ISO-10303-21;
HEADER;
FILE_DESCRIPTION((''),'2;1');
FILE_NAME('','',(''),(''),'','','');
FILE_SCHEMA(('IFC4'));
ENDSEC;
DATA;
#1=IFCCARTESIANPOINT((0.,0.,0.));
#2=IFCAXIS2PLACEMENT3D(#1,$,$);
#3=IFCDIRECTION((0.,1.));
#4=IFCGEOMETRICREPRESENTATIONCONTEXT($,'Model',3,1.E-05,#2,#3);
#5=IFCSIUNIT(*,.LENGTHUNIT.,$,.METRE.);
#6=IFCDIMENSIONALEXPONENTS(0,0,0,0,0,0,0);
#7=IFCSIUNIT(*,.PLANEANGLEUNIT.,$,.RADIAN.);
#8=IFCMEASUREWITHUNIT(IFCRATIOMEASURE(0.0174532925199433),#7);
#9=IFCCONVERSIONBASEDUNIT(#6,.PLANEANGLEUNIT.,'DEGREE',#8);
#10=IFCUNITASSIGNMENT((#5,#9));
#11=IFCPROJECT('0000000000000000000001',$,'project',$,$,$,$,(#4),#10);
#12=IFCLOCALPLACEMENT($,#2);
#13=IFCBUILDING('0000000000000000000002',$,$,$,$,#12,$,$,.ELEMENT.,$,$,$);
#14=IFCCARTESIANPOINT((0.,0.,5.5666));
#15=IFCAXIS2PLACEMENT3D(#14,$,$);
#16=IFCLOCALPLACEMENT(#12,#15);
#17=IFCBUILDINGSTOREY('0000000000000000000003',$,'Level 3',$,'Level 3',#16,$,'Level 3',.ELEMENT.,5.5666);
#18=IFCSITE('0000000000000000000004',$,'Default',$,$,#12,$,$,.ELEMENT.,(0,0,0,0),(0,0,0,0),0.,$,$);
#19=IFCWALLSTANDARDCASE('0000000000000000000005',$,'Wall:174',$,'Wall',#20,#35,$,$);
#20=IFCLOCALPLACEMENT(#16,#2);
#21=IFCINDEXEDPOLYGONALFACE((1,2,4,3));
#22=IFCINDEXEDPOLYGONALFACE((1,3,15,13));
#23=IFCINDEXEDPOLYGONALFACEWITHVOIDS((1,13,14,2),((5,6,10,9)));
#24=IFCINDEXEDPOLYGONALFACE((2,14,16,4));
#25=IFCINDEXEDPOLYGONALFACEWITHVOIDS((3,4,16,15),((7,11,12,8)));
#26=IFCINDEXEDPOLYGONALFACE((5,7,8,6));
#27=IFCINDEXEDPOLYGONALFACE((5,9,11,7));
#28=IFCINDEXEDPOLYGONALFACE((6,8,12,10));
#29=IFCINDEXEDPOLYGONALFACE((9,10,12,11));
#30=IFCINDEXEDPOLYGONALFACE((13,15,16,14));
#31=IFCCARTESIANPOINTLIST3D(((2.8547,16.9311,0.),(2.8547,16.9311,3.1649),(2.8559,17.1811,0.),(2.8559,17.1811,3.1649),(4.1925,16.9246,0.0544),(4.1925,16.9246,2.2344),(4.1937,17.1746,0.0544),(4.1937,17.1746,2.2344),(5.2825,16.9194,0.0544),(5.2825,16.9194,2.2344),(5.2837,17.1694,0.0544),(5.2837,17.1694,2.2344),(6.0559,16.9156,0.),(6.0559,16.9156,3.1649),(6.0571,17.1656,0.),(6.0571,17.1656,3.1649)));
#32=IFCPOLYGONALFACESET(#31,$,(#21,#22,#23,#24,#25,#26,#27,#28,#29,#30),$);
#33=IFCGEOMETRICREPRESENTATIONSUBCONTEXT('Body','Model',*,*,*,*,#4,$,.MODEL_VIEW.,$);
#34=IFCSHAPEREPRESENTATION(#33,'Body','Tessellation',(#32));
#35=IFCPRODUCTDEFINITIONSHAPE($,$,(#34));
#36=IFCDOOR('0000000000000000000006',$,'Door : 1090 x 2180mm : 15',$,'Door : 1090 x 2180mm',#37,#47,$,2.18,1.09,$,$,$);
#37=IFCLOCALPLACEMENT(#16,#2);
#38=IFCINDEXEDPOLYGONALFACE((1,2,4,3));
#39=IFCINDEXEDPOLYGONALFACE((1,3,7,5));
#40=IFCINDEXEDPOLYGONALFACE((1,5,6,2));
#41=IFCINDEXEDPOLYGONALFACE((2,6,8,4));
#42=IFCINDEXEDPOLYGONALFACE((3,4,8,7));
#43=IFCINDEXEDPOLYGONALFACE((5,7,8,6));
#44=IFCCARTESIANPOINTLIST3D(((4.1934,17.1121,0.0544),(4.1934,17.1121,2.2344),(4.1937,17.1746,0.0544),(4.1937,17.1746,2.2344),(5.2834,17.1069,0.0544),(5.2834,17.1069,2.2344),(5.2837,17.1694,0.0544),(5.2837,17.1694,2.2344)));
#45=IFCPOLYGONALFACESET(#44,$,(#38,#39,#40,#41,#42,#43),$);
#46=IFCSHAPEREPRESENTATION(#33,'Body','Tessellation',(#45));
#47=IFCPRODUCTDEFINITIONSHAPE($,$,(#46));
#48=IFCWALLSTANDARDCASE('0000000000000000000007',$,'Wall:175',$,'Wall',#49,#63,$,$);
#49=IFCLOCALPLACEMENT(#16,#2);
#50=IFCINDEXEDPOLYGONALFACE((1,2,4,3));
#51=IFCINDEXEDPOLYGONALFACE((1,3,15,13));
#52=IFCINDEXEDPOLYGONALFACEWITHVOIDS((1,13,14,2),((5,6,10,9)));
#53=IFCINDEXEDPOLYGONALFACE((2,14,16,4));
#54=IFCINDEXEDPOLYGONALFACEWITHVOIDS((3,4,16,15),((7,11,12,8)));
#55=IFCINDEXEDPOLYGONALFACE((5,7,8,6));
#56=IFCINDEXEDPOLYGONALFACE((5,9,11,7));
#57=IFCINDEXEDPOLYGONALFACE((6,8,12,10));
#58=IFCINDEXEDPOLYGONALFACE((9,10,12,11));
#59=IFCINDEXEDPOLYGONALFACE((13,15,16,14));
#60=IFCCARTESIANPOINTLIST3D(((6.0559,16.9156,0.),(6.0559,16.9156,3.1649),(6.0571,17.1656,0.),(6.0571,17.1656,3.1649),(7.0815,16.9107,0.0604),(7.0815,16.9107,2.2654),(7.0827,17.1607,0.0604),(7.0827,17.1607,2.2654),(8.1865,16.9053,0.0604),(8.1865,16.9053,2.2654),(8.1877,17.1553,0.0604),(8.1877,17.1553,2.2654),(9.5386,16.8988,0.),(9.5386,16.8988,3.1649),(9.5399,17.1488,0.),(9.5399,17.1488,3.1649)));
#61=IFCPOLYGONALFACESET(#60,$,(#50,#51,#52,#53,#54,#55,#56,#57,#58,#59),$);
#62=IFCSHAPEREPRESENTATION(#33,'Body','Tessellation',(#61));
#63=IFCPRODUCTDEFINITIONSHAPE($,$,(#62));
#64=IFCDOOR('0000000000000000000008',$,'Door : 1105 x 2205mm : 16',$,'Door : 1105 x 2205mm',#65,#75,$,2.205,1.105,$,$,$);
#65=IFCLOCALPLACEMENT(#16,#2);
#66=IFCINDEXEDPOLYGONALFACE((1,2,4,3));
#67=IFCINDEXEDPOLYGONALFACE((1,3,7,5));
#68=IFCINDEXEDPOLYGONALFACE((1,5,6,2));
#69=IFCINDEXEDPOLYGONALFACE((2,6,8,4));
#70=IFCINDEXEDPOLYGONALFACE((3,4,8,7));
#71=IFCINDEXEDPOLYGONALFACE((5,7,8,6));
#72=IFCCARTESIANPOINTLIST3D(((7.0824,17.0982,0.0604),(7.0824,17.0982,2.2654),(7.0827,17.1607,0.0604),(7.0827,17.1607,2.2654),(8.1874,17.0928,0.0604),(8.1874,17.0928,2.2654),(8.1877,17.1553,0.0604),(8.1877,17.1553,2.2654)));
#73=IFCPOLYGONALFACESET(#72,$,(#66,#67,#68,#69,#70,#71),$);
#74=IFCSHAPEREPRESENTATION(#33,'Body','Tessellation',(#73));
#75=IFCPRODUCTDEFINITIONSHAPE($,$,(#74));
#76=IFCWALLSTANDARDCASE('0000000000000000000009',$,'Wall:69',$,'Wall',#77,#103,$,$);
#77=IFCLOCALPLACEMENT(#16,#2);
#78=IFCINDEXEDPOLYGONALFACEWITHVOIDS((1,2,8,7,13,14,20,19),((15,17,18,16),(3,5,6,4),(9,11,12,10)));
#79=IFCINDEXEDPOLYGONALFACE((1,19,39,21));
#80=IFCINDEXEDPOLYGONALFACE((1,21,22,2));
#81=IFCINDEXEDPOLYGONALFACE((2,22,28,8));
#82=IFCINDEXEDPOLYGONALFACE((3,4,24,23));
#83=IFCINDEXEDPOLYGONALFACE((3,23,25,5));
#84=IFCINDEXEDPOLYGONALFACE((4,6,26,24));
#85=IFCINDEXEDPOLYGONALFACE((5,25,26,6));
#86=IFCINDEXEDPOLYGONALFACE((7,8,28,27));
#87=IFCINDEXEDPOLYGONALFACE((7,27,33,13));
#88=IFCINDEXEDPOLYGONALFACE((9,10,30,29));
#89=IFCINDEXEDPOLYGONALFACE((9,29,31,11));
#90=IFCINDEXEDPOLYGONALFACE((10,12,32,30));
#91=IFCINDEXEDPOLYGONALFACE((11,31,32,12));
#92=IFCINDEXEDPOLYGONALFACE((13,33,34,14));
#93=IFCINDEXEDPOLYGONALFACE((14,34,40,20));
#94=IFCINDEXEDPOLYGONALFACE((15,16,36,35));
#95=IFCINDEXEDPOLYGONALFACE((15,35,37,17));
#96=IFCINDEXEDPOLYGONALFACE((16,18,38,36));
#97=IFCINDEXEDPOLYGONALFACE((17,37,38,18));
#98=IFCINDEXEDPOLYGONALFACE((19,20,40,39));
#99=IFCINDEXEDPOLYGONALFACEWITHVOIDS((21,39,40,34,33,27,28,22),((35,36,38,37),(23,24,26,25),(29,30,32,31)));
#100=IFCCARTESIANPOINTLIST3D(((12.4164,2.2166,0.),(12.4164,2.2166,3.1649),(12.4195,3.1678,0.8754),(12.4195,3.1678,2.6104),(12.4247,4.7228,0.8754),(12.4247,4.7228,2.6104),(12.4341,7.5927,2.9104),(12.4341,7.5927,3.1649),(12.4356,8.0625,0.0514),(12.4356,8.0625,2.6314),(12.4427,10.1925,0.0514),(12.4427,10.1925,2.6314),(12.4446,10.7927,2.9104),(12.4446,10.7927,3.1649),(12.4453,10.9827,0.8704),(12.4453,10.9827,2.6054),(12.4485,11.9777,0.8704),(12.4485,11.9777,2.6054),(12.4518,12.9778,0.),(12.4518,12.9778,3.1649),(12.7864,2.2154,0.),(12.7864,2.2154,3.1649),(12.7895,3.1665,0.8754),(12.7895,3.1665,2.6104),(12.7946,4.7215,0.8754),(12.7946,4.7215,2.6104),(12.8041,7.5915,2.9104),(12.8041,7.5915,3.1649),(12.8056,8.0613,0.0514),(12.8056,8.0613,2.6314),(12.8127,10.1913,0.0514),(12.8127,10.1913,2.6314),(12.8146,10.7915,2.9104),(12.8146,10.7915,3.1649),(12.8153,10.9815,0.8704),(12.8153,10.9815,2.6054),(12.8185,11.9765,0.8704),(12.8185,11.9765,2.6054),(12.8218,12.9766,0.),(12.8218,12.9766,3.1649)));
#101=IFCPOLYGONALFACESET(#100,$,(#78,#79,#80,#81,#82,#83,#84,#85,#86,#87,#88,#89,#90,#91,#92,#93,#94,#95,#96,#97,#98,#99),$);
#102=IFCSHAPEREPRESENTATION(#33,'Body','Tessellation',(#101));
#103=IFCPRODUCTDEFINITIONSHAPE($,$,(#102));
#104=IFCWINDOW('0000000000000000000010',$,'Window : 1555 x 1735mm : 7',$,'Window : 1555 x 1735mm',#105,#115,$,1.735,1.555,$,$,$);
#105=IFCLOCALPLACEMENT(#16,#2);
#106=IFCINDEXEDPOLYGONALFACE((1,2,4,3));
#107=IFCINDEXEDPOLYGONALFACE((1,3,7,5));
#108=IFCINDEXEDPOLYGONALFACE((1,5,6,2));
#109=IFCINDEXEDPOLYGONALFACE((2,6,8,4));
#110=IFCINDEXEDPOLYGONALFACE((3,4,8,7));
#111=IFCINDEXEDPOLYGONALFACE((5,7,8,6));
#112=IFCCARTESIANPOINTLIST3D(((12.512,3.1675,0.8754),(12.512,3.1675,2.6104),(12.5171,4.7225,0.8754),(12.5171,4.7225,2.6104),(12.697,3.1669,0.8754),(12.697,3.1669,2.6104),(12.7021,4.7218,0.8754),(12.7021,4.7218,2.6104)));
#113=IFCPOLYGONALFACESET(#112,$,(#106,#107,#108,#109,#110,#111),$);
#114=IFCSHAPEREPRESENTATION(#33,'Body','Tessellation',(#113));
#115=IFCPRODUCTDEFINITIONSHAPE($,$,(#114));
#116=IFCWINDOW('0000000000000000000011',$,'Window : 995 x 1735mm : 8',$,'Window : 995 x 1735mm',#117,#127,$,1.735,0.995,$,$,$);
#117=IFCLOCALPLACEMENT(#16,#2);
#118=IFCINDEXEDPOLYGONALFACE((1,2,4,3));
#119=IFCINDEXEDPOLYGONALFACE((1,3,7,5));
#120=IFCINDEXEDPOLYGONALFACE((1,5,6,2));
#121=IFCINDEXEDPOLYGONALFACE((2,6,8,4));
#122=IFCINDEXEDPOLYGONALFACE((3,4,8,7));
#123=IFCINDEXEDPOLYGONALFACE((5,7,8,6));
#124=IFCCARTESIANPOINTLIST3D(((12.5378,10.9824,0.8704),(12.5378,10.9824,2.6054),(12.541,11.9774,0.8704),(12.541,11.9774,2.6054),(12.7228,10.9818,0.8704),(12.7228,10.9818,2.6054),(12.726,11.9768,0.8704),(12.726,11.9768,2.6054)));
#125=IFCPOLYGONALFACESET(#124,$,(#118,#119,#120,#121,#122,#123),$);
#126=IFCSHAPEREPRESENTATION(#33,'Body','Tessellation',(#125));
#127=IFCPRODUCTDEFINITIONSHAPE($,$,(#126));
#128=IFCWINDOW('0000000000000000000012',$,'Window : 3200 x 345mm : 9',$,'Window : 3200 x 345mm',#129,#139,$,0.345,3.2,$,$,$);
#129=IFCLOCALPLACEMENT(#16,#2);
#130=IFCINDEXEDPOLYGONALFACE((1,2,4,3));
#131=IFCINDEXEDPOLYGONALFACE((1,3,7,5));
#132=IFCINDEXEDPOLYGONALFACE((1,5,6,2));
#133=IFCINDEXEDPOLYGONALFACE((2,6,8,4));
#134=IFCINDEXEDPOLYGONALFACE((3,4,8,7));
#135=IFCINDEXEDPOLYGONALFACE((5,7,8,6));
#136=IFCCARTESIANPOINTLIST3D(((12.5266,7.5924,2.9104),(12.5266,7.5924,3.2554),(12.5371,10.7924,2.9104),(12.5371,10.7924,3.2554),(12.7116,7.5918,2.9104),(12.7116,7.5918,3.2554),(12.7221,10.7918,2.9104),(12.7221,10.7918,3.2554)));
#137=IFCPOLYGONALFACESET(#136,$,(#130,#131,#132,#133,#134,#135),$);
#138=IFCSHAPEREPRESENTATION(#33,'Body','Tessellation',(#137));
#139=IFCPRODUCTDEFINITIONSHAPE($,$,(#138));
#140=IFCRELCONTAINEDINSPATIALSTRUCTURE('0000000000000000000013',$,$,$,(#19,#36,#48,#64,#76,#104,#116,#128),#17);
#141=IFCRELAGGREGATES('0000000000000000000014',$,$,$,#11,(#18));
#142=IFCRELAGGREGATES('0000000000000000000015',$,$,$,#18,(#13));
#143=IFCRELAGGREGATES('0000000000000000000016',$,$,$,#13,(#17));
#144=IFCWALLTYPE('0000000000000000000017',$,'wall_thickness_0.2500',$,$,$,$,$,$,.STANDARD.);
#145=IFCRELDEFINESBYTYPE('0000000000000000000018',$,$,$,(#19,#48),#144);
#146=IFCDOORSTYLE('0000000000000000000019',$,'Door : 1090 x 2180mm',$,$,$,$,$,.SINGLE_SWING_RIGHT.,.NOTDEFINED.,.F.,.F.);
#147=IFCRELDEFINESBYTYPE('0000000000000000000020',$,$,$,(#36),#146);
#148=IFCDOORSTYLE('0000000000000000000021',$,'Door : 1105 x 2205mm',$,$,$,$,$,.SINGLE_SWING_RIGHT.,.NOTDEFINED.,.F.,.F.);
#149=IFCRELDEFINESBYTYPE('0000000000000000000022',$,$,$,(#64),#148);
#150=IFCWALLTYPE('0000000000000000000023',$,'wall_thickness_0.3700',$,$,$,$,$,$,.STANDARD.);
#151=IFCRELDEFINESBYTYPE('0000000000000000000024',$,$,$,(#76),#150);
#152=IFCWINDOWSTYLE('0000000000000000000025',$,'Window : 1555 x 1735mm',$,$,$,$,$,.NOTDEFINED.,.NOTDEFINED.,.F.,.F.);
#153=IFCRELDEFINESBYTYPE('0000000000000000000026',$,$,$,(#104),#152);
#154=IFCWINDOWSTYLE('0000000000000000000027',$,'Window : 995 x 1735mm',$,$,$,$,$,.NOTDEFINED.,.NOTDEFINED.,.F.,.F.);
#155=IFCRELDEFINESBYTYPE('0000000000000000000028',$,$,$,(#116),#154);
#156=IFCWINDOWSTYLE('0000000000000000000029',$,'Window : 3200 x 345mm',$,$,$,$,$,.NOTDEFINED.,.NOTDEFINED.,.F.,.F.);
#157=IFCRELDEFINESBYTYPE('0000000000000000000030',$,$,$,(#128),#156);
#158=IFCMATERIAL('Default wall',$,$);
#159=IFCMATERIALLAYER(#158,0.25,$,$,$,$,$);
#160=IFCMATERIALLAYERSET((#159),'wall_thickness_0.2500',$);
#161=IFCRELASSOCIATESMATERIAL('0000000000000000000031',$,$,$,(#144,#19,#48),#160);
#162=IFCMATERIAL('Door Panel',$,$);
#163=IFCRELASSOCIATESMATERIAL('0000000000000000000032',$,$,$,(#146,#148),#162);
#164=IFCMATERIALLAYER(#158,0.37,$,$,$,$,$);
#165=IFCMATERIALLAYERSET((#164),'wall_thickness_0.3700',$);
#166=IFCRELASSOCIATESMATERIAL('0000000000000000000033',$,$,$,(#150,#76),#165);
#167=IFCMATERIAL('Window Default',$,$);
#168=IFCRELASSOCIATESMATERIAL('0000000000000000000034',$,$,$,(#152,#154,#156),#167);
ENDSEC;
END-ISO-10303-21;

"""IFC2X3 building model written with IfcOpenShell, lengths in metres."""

from ifc_helpers import new_model, entity, si_unit, converted_unit, direction, frame, frame_2d, origin, origin_2d_with_axis, place, context, subcontext, project, spatial, polyline, rectangle, outline, extrude, source, transform, mapped, material, layer, layer_set, layer_usage, type_object, type_shapes, element, fill, save


model = new_model("IFC2X3")

# Units and contexts
model_context = context("Model", 3, precision=1e-05, world=origin(), true_north=direction((0.0, 1.0)))
body_context = subcontext(model_context, "Body", "Model", "MODEL_VIEW")
ifc_project = project(units=[si_unit("LENGTHUNIT", "METRE"), converted_unit("PLANEANGLEUNIT", "DEGREE", entity("IfcRatioMeasure", 0.0174532925199433), si_unit("PLANEANGLEUNIT", "RADIAN"), dimensions=[0, 0, 0, 0, 0, 0, 0])], contexts=[model_context])

# Site, building, storey
placement_1 = place(None, origin())
site = spatial("IfcSite", under=ifc_project, at=placement_1, Name="Default", CompositionType="ELEMENT", RefLatitude=(0, 0, 0, 0), RefLongitude=(0, 0, 0, 0), RefElevation=0.0)
building = spatial("IfcBuilding", under=site, at=placement_1, CompositionType="ELEMENT")
storey_placement = place(placement_1, frame((0.0, 0.0, 5.5666)))
storey = spatial("IfcBuildingStorey", under=building, at=storey_placement, Name="Level 3", ObjectType="Level 3", LongName="Level 3", CompositionType="ELEMENT", Elevation=5.5666)

# Shared definitions
ifc_material_1 = material(Name="Default wall")

# Shared definitions
ifc_material_2 = material(Name="Window Default")

# Shared definitions
ifc_layer_1 = layer(ifc_material_1, 0.25)
ifc_layer_set_1 = layer_set([ifc_layer_1], Name="wall_thickness_0.2500")
ifc_layer_usage_1 = layer_usage(ifc_layer_set_1, "AXIS2", "POSITIVE", -0.125)
wall_type_1 = type_object("IfcWallType", Name="wall_thickness_0.2500", PredefinedType="STANDARD", material=ifc_layer_set_1)

# Walls, openings, doors
wall_1_placement = place(storey_placement, frame((2.8553, 17.0561, 0.0), z_axis=(0.0, 0.0, 1.0), x_axis=(0.999988, -0.004836, 0.0)))
wall_1 = element("IfcWallStandardCase", 1, at=wall_1_placement, inside=storey, type_object=wall_type_1, material=ifc_layer_usage_1, Name="Wall:174", ObjectType="Wall", context=body_context, shape_type="SweptSolid", body=[
    extrude(outline(polyline([(3.2013, -0.125), (3.2013, 0.125), (0.0, 0.125), (0.0, -0.125), (3.2013, -0.125)])), origin(), (0.0, 0.0, 1.0), 3.1649),
])
opening_1_placement = place(wall_1_placement, frame((1.3378, -0.125, 0.0544)))
opening_1 = element("IfcOpeningElement", 2, at=opening_1_placement, cuts=wall_1, ObjectType="Opening", context=body_context, shape_type="SweptSolid", body=[
    extrude(rectangle(XDim=1.09, YDim=2.18, at=frame_2d((1.09, 0.545), x_axis=(0.0, 1.0))), frame((0.0, 0.0, 0.0), z_axis=(0.0, 1.0, 0.0), x_axis=(0.0, 0.0, 1.0)), (0.0, 0.0, 1.0), 0.25),
])
ifc_material_3 = material(Name="Door Panel")
door_style_1 = type_object("IfcDoorStyle", Name="Door : 1090 x 2180mm", ConstructionType="NOTDEFINED", OperationType="SINGLE_SWING_RIGHT", ParameterTakesPrecedence=False, Sizeable=False, material=ifc_material_3)
shared_shape_1 = source(origin(), body_context, "Body", "SweptSolid", [
    extrude(rectangle(XDim=0.0625, YDim=1.09, at=origin_2d_with_axis()), frame((0.545, 0.2188, 0.0), z_axis=(0.0, 0.0, 1.0), x_axis=(0.0, 1.0, 0.0)), (0.0, 0.0, 1.0), 2.18),
])
type_shapes(door_style_1, [shared_shape_1])
door_1_placement = place(opening_1_placement, origin())
door_1 = element("IfcDoor", 3, at=door_1_placement, inside=storey, type_object=door_style_1, Name="Door : 1090 x 2180mm : 15", ObjectType="Door : 1090 x 2180mm", OverallHeight=2.18, OverallWidth=1.09, context=body_context, shape_type="MappedRepresentation", body=[
    mapped(shared_shape_1, transform((0.0, 0.0, 0.0), scale=1.0)),
])
fill(opening_1, door_1)
wall_2_placement = place(storey_placement, frame((6.0565, 17.0406, 0.0), z_axis=(0.0, 0.0, 1.0), x_axis=(0.999988, -0.004836, 0.0)))
wall_2 = element("IfcWallStandardCase", 4, at=wall_2_placement, inside=storey, type_object=wall_type_1, material=ifc_layer_usage_1, Name="Wall:175", ObjectType="Wall", context=body_context, shape_type="SweptSolid", body=[
    extrude(outline(polyline([(3.4828, -0.125), (3.4828, 0.125), (0.0, 0.125), (0.0, -0.125), (3.4828, -0.125)])), origin(), (0.0, 0.0, 1.0), 3.1649),
])
opening_2_placement = place(wall_2_placement, frame((1.0256, -0.125, 0.0604)))
opening_2 = element("IfcOpeningElement", 5, at=opening_2_placement, cuts=wall_2, ObjectType="Opening", context=body_context, shape_type="SweptSolid", body=[
    extrude(rectangle(XDim=1.105, YDim=2.205, at=frame_2d((1.1025, 0.5525), x_axis=(0.0, 1.0))), frame((0.0, 0.0, 0.0), z_axis=(0.0, 1.0, 0.0), x_axis=(0.0, 0.0, 1.0)), (0.0, 0.0, 1.0), 0.25),
])
door_style_2 = type_object("IfcDoorStyle", Name="Door : 1105 x 2205mm", ConstructionType="NOTDEFINED", OperationType="SINGLE_SWING_RIGHT", ParameterTakesPrecedence=False, Sizeable=False, material=ifc_material_3)
shared_shape_2 = source(origin(), body_context, "Body", "SweptSolid", [
    extrude(rectangle(XDim=0.0625, YDim=1.105, at=origin_2d_with_axis()), frame((0.5525, 0.2188, 0.0), z_axis=(0.0, 0.0, 1.0), x_axis=(0.0, 1.0, 0.0)), (0.0, 0.0, 1.0), 2.205),
])
type_shapes(door_style_2, [shared_shape_2])
door_2_placement = place(opening_2_placement, origin())
door_2 = element("IfcDoor", 6, at=door_2_placement, inside=storey, type_object=door_style_2, Name="Door : 1105 x 2205mm : 16", ObjectType="Door : 1105 x 2205mm", OverallHeight=2.205, OverallWidth=1.105, context=body_context, shape_type="MappedRepresentation", body=[
    mapped(shared_shape_2, transform((0.0, 0.0, 0.0), scale=1.0)),
])
fill(opening_2, door_2)

# Wall, openings, windows
ifc_layer_2 = layer(ifc_material_1, 0.37)
ifc_layer_set_2 = layer_set([ifc_layer_2], Name="wall_thickness_0.3700")
ifc_layer_usage_2 = layer_usage(ifc_layer_set_2, "AXIS2", "POSITIVE", -0.185)
wall_type_2 = type_object("IfcWallType", Name="wall_thickness_0.3700", PredefinedType="STANDARD", material=ifc_layer_set_2)
wall_3_placement = place(storey_placement, frame((12.6368, 12.9772, 0.0), z_axis=(0.0, 0.0, 1.0), x_axis=(-0.003292, -0.999995, 0.0)))
wall_3 = element("IfcWallStandardCase", 7, at=wall_3_placement, inside=storey, type_object=wall_type_2, material=ifc_layer_usage_2, Name="Wall:69", ObjectType="Wall", context=body_context, shape_type="SweptSolid", body=[
    extrude(outline(polyline([(10.7612, -0.185), (10.7612, 0.185), (0.0, 0.185), (0.0, -0.185), (10.7612, -0.185)])), origin(), (0.0, 0.0, 1.0), 3.1649),
])
opening_3_placement = place(wall_3_placement, frame((2.7853, -0.185, 0.0514)))
element("IfcOpeningElement", 8, at=opening_3_placement, cuts=wall_3, ObjectType="Opening", context=body_context, shape_type="SweptSolid", body=[
    extrude(rectangle(XDim=2.13, YDim=2.58, at=frame_2d((1.29, 1.065), x_axis=(0.0, 1.0))), frame((0.0, 0.0, 0.0), z_axis=(0.0, 1.0, 0.0), x_axis=(0.0, 0.0, 1.0)), (0.0, 0.0, 1.0), 0.37),
])
opening_4_placement = place(wall_3_placement, frame((8.2551, -0.185, 0.8754)))
opening_4 = element("IfcOpeningElement", 9, at=opening_4_placement, cuts=wall_3, ObjectType="Opening", context=body_context, shape_type="SweptSolid", body=[
    extrude(rectangle(XDim=1.555, YDim=1.735, at=frame_2d((0.8675, 0.7775), x_axis=(0.0, 1.0))), frame((0.0, 0.0, 0.0), z_axis=(0.0, 1.0, 0.0), x_axis=(0.0, 0.0, 1.0)), (0.0, 0.0, 1.0), 0.37),
])
opening_5_placement = place(wall_3_placement, frame((1.0001, -0.185, 0.8704)))
opening_5 = element("IfcOpeningElement", 10, at=opening_5_placement, cuts=wall_3, ObjectType="Opening", context=body_context, shape_type="SweptSolid", body=[
    extrude(rectangle(XDim=0.995, YDim=1.735, at=frame_2d((0.8675, 0.4975), x_axis=(0.0, 1.0))), frame((0.0, 0.0, 0.0), z_axis=(0.0, 1.0, 0.0), x_axis=(0.0, 0.0, 1.0)), (0.0, 0.0, 1.0), 0.37),
])
opening_6_placement = place(wall_3_placement, frame((2.1851, -0.185, 2.9104)))
opening_6 = element("IfcOpeningElement", 11, at=opening_6_placement, cuts=wall_3, ObjectType="Opening", context=body_context, shape_type="SweptSolid", body=[
    extrude(rectangle(XDim=3.2, YDim=0.345, at=frame_2d((0.1725, 1.6), x_axis=(0.0, 1.0))), frame((0.0, 0.0, 0.0), z_axis=(0.0, 1.0, 0.0), x_axis=(0.0, 0.0, 1.0)), (0.0, 0.0, 1.0), 0.37),
])
window_style_1 = type_object("IfcWindowStyle", Name="Window : 1555 x 1735mm", ConstructionType="NOTDEFINED", OperationType="NOTDEFINED", ParameterTakesPrecedence=False, Sizeable=False, material=ifc_material_2)
shared_shape_3 = source(origin(), body_context, "Body", "SweptSolid", [
    extrude(rectangle(XDim=0.185, YDim=1.555, at=origin_2d_with_axis()), frame((0.7775, 0.185, 0.0), z_axis=(0.0, 0.0, 1.0), x_axis=(0.0, 1.0, 0.0)), (0.0, 0.0, 1.0), 1.735),
])
type_shapes(window_style_1, [shared_shape_3])
window_1_placement = place(opening_4_placement, origin())
window_1 = element("IfcWindow", 12, at=window_1_placement, inside=storey, type_object=window_style_1, Name="Window : 1555 x 1735mm : 7", ObjectType="Window : 1555 x 1735mm", OverallHeight=1.735, OverallWidth=1.555, context=body_context, shape_type="MappedRepresentation", body=[
    mapped(shared_shape_3, transform((0.0, 0.0, 0.0), scale=1.0)),
])
fill(opening_4, window_1)
window_style_2 = type_object("IfcWindowStyle", Name="Window : 995 x 1735mm", ConstructionType="NOTDEFINED", OperationType="NOTDEFINED", ParameterTakesPrecedence=False, Sizeable=False, material=ifc_material_2)
shared_shape_4 = source(origin(), body_context, "Body", "SweptSolid", [
    extrude(rectangle(XDim=0.185, YDim=0.995, at=origin_2d_with_axis()), frame((0.4975, 0.185, 0.0), z_axis=(0.0, 0.0, 1.0), x_axis=(0.0, 1.0, 0.0)), (0.0, 0.0, 1.0), 1.735),
])
type_shapes(window_style_2, [shared_shape_4])
window_2_placement = place(opening_5_placement, origin())
window_2 = element("IfcWindow", 13, at=window_2_placement, inside=storey, type_object=window_style_2, Name="Window : 995 x 1735mm : 8", ObjectType="Window : 995 x 1735mm", OverallHeight=1.735, OverallWidth=0.995, context=body_context, shape_type="MappedRepresentation", body=[
    mapped(shared_shape_4, transform((0.0, 0.0, 0.0), scale=1.0)),
])
fill(opening_5, window_2)
window_style_3 = type_object("IfcWindowStyle", Name="Window : 3200 x 345mm", ConstructionType="NOTDEFINED", OperationType="NOTDEFINED", ParameterTakesPrecedence=False, Sizeable=False, material=ifc_material_2)
shared_shape_5 = source(origin(), body_context, "Body", "SweptSolid", [
    extrude(rectangle(XDim=0.185, YDim=3.2, at=origin_2d_with_axis()), frame((1.6, 0.185, 0.0), z_axis=(0.0, 0.0, 1.0), x_axis=(0.0, 1.0, 0.0)), (0.0, 0.0, 1.0), 0.345),
])
type_shapes(window_style_3, [shared_shape_5])
window_3_placement = place(opening_6_placement, origin())
window_3 = element("IfcWindow", 14, at=window_3_placement, inside=storey, type_object=window_style_3, Name="Window : 3200 x 345mm : 9", ObjectType="Window : 3200 x 345mm", OverallHeight=0.345, OverallWidth=3.2, context=body_context, shape_type="MappedRepresentation", body=[
    mapped(shared_shape_5, transform((0.0, 0.0, 0.0), scale=1.0)),
])
fill(opening_6, window_3)

save(model, "model.ifc")
